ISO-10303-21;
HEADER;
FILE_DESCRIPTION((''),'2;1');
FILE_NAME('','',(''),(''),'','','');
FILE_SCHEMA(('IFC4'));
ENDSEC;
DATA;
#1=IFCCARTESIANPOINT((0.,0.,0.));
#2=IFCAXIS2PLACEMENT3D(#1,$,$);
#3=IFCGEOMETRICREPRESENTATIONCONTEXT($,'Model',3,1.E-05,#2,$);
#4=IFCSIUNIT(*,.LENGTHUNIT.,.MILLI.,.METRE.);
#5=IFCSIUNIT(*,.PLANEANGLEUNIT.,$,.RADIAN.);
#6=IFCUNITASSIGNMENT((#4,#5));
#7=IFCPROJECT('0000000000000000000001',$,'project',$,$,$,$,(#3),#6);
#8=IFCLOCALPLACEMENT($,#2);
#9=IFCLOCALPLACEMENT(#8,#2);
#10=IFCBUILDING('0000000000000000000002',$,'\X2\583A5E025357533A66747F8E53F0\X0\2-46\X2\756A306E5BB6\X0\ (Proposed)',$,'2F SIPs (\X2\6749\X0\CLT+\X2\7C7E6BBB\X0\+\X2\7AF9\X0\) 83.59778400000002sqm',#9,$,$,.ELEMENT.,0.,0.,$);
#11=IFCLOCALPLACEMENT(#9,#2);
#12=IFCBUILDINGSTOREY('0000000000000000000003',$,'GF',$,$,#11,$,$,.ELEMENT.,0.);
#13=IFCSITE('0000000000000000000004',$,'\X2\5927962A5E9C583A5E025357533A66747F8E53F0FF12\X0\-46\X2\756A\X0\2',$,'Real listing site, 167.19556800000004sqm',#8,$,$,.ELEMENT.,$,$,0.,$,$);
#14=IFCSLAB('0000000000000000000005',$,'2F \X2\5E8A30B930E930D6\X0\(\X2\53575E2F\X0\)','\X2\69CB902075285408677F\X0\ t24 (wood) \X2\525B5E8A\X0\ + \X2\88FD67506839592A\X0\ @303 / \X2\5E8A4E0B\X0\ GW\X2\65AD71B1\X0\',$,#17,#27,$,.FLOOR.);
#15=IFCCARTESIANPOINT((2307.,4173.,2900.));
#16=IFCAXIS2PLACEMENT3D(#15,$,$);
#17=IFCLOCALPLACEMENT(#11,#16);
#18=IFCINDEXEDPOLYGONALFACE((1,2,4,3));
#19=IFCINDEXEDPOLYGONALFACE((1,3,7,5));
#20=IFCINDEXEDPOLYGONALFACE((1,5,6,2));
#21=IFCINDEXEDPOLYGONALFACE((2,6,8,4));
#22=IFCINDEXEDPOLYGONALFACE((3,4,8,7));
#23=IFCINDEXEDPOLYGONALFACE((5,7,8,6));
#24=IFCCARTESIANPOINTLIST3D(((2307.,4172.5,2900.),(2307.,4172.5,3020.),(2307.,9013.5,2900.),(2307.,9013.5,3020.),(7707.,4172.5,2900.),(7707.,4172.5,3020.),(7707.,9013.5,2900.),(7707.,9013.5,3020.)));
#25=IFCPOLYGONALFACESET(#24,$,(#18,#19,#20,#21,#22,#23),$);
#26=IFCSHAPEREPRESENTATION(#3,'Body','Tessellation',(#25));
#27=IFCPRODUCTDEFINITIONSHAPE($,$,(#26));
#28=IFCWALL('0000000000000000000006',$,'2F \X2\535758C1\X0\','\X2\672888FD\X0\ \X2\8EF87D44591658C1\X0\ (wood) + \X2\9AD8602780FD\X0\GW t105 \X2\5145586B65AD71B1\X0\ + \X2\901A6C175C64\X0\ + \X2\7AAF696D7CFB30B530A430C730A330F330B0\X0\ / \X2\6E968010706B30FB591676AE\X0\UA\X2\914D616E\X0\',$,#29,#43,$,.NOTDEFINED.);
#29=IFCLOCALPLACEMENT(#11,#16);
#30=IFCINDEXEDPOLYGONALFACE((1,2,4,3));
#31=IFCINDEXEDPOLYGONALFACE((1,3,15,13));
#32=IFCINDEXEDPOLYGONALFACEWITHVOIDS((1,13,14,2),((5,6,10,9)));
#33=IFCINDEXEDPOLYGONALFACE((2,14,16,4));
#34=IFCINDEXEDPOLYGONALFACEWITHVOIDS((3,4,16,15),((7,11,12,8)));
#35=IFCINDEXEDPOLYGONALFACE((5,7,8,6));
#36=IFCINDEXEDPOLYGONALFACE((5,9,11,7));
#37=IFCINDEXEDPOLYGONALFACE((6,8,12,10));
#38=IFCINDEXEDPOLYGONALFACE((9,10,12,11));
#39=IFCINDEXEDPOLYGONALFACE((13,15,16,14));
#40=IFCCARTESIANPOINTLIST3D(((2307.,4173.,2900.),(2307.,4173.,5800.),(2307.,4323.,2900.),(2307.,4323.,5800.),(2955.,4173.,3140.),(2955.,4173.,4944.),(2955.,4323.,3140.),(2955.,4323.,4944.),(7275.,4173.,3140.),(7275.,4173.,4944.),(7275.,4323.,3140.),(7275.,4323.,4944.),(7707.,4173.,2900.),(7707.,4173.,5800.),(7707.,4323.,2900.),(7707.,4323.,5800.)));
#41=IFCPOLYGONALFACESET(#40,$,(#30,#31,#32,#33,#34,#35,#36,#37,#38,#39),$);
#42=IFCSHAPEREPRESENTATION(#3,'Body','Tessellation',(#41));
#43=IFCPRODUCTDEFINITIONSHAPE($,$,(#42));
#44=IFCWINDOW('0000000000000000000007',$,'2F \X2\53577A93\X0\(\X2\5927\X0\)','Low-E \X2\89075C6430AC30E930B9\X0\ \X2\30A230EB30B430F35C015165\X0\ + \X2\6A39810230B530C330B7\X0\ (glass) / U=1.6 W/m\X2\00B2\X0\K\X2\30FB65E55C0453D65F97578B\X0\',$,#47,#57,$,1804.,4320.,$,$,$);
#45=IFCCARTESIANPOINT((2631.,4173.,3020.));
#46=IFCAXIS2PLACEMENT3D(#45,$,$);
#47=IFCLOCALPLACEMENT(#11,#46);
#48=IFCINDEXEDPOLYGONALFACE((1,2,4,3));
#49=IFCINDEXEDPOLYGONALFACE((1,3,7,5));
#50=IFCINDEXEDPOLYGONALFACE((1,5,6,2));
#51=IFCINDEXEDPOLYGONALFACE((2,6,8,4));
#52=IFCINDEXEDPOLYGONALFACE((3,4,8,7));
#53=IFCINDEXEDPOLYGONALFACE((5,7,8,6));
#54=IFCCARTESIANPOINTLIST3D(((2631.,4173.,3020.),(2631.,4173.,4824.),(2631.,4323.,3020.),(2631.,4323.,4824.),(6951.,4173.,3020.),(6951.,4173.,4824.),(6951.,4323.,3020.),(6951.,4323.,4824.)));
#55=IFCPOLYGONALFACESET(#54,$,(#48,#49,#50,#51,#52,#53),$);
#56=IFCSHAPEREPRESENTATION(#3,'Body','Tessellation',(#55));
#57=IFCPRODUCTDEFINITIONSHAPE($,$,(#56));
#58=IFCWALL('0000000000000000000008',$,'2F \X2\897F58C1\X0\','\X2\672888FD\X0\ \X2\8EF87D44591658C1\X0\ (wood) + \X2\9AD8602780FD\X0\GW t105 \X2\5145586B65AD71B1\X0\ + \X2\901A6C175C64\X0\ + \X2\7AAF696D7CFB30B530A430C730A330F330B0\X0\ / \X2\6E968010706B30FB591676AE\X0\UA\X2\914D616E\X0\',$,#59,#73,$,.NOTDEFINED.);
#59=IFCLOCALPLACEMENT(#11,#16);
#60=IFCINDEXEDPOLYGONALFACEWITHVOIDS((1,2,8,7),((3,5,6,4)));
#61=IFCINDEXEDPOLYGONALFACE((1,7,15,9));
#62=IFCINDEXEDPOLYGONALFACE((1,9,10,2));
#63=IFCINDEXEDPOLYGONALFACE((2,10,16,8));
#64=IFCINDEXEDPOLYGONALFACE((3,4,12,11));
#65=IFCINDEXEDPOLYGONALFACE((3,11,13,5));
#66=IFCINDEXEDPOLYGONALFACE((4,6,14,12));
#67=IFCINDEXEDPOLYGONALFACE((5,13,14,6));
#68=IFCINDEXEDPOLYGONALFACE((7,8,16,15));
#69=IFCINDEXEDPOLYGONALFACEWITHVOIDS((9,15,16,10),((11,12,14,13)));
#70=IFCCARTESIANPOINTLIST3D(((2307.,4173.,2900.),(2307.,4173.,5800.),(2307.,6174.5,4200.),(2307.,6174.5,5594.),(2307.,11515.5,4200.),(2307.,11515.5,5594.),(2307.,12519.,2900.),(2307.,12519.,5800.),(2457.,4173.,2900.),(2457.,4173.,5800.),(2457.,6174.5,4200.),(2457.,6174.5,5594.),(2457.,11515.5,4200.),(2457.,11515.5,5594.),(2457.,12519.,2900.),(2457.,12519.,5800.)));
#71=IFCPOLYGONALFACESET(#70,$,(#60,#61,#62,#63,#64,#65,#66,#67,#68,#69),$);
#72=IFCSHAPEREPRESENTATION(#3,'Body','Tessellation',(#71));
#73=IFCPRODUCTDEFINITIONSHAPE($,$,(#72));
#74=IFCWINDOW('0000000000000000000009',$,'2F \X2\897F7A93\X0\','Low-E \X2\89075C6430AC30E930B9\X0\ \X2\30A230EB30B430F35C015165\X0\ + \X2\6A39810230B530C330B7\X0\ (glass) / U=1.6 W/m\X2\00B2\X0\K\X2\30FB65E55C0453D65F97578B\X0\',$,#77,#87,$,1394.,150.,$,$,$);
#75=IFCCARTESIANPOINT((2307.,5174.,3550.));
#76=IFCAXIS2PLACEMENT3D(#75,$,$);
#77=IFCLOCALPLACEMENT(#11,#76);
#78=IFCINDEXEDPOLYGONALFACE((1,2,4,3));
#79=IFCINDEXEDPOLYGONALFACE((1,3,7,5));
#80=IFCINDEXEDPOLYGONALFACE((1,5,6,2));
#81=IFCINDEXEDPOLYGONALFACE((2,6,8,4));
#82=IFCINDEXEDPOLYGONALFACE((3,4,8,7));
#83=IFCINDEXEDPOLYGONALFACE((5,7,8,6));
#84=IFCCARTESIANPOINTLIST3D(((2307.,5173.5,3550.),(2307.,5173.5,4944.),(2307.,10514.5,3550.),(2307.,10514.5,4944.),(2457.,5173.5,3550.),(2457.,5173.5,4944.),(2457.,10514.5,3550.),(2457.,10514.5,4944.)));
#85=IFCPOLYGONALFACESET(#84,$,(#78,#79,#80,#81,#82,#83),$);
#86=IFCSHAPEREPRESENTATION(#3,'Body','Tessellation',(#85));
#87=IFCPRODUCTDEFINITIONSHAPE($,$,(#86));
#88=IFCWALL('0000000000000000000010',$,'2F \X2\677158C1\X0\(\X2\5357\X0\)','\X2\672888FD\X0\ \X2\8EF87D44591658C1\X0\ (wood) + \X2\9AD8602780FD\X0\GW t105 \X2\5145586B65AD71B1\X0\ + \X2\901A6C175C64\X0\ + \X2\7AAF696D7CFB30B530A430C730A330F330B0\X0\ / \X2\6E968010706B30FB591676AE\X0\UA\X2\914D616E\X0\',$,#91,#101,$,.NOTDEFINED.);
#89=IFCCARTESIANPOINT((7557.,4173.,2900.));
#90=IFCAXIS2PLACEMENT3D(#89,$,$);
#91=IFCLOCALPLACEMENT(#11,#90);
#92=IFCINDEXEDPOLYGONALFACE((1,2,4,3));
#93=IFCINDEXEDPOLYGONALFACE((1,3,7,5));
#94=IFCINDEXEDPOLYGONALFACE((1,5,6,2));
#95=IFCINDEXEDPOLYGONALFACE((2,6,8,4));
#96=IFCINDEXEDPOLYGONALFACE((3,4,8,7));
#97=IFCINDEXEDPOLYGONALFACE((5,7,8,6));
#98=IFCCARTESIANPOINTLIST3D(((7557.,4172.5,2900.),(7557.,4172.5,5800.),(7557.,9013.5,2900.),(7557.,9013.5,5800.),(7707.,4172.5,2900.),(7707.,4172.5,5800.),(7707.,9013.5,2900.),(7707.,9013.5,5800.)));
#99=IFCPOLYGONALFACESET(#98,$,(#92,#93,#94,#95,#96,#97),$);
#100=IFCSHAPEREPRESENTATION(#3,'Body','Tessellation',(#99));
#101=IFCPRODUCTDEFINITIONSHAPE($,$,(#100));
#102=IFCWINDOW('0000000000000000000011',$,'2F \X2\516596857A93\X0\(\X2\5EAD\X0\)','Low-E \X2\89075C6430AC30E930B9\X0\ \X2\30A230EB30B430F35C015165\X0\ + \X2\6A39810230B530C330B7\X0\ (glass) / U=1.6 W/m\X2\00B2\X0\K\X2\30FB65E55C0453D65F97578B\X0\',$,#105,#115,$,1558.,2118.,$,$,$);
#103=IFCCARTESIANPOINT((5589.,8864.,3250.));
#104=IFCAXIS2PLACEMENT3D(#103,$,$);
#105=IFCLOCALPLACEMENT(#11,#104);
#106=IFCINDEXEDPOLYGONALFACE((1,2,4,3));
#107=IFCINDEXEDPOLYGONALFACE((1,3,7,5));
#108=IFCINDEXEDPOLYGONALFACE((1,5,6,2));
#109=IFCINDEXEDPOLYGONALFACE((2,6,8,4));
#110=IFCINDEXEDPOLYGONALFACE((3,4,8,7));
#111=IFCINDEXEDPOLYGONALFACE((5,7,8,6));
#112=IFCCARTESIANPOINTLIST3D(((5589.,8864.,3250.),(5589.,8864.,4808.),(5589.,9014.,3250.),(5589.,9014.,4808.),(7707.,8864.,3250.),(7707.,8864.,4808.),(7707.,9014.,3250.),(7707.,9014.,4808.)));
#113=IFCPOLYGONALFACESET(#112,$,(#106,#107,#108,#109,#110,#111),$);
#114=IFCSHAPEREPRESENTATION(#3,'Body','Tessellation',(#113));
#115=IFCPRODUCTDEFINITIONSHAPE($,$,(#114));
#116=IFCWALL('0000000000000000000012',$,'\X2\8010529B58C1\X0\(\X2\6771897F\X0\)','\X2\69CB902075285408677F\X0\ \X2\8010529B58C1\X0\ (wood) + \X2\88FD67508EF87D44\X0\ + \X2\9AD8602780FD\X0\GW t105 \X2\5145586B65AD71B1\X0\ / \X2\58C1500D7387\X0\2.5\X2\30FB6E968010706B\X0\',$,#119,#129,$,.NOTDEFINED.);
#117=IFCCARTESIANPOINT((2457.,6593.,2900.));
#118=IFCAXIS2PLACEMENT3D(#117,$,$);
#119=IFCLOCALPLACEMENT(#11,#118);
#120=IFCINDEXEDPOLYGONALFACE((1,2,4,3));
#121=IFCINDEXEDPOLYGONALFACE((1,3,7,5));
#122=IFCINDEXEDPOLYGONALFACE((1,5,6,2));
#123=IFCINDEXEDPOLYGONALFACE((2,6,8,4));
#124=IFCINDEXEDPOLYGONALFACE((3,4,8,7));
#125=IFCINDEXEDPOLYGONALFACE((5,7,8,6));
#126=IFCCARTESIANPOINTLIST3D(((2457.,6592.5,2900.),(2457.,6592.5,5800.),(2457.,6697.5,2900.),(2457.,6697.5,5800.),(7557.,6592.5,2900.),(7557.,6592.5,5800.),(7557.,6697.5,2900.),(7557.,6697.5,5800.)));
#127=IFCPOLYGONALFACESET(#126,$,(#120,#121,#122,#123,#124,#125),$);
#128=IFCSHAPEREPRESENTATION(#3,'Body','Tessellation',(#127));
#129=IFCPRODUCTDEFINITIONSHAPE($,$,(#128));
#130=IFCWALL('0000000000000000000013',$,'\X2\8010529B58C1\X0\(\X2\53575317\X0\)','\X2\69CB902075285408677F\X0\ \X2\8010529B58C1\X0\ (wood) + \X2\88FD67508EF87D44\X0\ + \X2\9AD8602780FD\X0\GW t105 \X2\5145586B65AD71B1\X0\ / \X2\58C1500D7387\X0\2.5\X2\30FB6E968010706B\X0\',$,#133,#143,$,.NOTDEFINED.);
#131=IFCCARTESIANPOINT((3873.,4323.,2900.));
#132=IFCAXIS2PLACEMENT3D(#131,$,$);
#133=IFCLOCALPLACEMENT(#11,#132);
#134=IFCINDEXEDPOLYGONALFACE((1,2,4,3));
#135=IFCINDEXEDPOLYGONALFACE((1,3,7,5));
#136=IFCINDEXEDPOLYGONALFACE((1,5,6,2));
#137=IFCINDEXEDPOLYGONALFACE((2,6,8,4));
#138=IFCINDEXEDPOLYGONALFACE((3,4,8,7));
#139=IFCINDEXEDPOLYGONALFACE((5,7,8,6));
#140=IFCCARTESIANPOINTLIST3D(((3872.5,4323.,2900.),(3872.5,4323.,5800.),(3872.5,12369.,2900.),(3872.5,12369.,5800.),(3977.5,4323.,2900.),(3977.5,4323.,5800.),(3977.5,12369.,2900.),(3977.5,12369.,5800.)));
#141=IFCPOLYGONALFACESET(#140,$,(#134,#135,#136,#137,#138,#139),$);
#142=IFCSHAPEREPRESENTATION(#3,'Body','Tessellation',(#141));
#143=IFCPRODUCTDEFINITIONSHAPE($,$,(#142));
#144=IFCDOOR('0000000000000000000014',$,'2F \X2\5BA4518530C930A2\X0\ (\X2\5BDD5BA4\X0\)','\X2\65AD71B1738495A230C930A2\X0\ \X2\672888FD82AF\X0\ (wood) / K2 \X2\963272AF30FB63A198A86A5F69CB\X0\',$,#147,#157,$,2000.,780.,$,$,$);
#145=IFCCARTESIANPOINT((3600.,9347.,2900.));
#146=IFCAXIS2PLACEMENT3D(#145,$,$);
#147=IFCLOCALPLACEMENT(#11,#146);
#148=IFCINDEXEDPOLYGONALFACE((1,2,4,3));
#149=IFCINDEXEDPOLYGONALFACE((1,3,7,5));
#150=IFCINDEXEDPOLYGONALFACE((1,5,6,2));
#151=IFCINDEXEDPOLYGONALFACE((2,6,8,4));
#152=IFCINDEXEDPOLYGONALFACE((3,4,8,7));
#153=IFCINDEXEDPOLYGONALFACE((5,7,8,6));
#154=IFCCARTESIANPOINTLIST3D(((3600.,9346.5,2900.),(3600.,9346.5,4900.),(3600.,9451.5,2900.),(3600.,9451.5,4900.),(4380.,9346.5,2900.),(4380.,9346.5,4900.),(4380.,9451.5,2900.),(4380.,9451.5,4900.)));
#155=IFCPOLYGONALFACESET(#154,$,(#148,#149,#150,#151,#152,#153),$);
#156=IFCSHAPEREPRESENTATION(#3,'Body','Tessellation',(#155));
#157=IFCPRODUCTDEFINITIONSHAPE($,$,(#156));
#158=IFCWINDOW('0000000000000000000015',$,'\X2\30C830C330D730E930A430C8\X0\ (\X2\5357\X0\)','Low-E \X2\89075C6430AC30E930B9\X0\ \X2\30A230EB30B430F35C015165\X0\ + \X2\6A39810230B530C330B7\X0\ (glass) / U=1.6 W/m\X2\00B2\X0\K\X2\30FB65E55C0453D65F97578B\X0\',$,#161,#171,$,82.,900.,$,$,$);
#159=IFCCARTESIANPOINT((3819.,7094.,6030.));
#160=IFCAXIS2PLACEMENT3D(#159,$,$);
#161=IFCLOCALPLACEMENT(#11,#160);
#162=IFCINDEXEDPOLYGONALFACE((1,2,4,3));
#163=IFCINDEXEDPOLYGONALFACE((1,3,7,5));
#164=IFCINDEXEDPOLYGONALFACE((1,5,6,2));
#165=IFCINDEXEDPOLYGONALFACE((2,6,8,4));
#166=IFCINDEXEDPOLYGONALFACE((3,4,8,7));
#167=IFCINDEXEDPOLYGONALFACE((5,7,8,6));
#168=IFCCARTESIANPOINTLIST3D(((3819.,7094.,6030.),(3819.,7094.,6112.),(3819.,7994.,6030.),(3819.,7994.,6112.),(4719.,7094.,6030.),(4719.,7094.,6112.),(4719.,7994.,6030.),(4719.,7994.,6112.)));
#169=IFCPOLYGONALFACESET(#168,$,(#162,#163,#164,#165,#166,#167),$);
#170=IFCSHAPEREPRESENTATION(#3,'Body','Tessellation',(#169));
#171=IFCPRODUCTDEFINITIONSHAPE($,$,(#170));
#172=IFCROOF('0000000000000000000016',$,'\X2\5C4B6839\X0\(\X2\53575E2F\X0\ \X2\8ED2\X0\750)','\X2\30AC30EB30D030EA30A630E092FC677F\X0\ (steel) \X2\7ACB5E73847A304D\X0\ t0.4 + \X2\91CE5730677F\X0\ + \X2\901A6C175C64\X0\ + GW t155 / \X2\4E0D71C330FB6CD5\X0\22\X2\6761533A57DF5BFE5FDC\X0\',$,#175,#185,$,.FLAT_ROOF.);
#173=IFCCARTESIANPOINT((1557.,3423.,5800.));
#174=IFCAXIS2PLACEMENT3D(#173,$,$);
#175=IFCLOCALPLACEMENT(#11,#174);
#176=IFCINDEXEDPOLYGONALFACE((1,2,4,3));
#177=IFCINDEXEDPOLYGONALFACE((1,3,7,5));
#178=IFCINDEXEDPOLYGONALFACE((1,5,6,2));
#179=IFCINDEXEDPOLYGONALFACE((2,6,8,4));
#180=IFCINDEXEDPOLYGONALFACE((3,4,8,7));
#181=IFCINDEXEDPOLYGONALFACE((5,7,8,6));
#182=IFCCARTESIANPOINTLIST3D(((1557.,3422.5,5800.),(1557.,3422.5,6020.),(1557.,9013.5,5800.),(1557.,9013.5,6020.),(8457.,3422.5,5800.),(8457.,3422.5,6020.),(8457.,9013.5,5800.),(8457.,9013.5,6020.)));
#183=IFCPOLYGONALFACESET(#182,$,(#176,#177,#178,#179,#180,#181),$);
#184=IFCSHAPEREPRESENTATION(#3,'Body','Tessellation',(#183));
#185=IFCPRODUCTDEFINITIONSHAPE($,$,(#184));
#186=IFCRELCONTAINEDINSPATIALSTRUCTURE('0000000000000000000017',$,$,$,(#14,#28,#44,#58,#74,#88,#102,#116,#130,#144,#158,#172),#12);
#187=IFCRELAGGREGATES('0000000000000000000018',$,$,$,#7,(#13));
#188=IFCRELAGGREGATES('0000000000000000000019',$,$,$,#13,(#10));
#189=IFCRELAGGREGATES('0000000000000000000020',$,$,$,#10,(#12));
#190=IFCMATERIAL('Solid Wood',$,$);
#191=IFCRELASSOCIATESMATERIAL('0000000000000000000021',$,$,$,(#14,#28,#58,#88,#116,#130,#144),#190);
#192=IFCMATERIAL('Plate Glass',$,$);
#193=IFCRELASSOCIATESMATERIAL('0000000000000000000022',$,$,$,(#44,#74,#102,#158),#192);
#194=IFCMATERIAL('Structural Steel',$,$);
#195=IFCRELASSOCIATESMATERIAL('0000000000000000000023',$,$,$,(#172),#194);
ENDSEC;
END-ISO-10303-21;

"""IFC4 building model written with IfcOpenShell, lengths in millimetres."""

from ifc_helpers import new_model, si_unit, frame, frame_2d, origin, place, context, project, spatial, rectangle, extrude, material, element, fill, save


model = new_model("IFC4")

# Units and contexts
model_context = context("Model", 3, precision=1e-05, world=origin())
ifc_project = project(units=[si_unit("LENGTHUNIT", "METRE", prefix="MILLI"), si_unit("PLANEANGLEUNIT", "RADIAN")], contexts=[model_context])

# Site, building, storey
site_placement = place(None, origin())
site = spatial("IfcSite", under=ifc_project, at=site_placement, Name="大阪府堺市南区晴美台２-46番2", ObjectType="Real listing site, 167.19556800000004sqm", CompositionType="ELEMENT", RefElevation=0.0)
building_placement = place(site_placement, origin())
building = spatial("IfcBuilding", under=site, at=building_placement, Name="堺市南区晴美台2-46番の家 (Proposed)", ObjectType="2F SIPs (杉CLT+籾殻+竹) 83.59778400000002sqm", CompositionType="ELEMENT", ElevationOfRefHeight=0.0, ElevationOfTerrain=0.0)
storey_placement = place(building_placement, origin())
storey = spatial("IfcBuildingStorey", under=building, at=storey_placement, Name="GF", CompositionType="ELEMENT", Elevation=0.0)

# Slab
ifc_material_1 = material(Name="Solid Wood")
slab_placement = place(storey_placement, frame((2307.0, 4173.0, 2900.0)))
element("IfcSlab", 1, at=slab_placement, inside=storey, material=ifc_material_1, Name="2F 床スラブ(南帯)", Description="構造用合板 t24 (wood) 剛床 + 製材根太 @303 / 床下 GW断熱", PredefinedType="FLOOR", context=model_context, shape_type="SweptSolid", body=[
    extrude(rectangle(XDim=5400.0, YDim=4841.0, at=frame_2d((2700.0, 2420.0))), frame((2307.0, 4173.0, 2900.0)), (0.0, 0.0, 1.0), 120.0),
])

# Walls, openings, windows
wall_1_placement = place(storey_placement, frame((2307.0, 4173.0, 2900.0)))
wall_1 = element("IfcWall", 2, at=wall_1_placement, inside=storey, material=ifc_material_1, Name="2F 南壁", Description="木製 軸組外壁 (wood) + 高性能GW t105 充填断熱 + 通気層 + 窯業系サイディング / 準耐火・外皮UA配慮", PredefinedType="NOTDEFINED", context=model_context, shape_type="SweptSolid", body=[
    extrude(rectangle(XDim=5400.0, YDim=150.0, at=frame_2d((2700.0, 75.0))), frame((2307.0, 4173.0, 2900.0)), (0.0, 0.0, 1.0), 2900.0),
])
opening_1_placement = place(storey_placement, frame((2631.0, 4173.0, 3020.0)))
opening_1 = element("IfcOpeningElement", 3, at=opening_1_placement, cuts=wall_1, PredefinedType="NOTDEFINED", context=model_context, shape_type="SweptSolid", body=[
    extrude(rectangle(XDim=4320.0, YDim=150.0, at=frame_2d((2160.0, 75.0))), frame((2631.0, 4173.0, 3020.0)), (0.0, 0.0, 1.0), 1804.0),
])
ifc_material_2 = material(Name="Plate Glass")
window_1_placement = place(storey_placement, frame((2631.0, 4173.0, 3020.0)))
window_1 = element("IfcWindow", 4, at=window_1_placement, inside=storey, material=ifc_material_2, Name="2F 南窓(大)", Description="Low-E 複層ガラス アルゴン封入 + 樹脂サッシ (glass) / U=1.6 W/m²K・日射取得型", OverallHeight=1804.0, OverallWidth=4320.0, context=model_context, shape_type="SweptSolid", body=[
    extrude(rectangle(XDim=4320.0, YDim=150.0, at=frame_2d((2160.0, 75.0))), frame((2631.0, 4173.0, 3020.0)), (0.0, 0.0, 1.0), 1804.0),
])
fill(opening_1, window_1)
wall_2_placement = place(storey_placement, frame((2307.0, 4173.0, 2900.0)))
wall_2 = element("IfcWall", 5, at=wall_2_placement, inside=storey, material=ifc_material_1, Name="2F 西壁", Description="木製 軸組外壁 (wood) + 高性能GW t105 充填断熱 + 通気層 + 窯業系サイディング / 準耐火・外皮UA配慮", PredefinedType="NOTDEFINED", context=model_context, shape_type="SweptSolid", body=[
    extrude(rectangle(XDim=150.0, YDim=8346.0, at=frame_2d((75.0, 4173.0))), frame((2307.0, 4173.0, 2900.0)), (0.0, 0.0, 1.0), 2900.0),
])
opening_2_placement = place(storey_placement, frame((2307.0, 5174.0, 3550.0)))
opening_2 = element("IfcOpeningElement", 6, at=opening_2_placement, cuts=wall_2, PredefinedType="NOTDEFINED", context=model_context, shape_type="SweptSolid", body=[
    extrude(rectangle(XDim=150.0, YDim=5341.0, at=frame_2d((75.0, 2670.0))), frame((2307.0, 5174.0, 3550.0)), (0.0, 0.0, 1.0), 1394.0),
])
window_2_placement = place(storey_placement, frame((2307.0, 5174.0, 3550.0)))
window_2 = element("IfcWindow", 7, at=window_2_placement, inside=storey, material=ifc_material_2, Name="2F 西窓", Description="Low-E 複層ガラス アルゴン封入 + 樹脂サッシ (glass) / U=1.6 W/m²K・日射取得型", OverallHeight=1394.0, OverallWidth=150.0, context=model_context, shape_type="SweptSolid", body=[
    extrude(rectangle(XDim=150.0, YDim=5341.0, at=frame_2d((75.0, 2670.0))), frame((2307.0, 5174.0, 3550.0)), (0.0, 0.0, 1.0), 1394.0),
])
fill(opening_2, window_2)
wall_3_placement = place(storey_placement, frame((7557.0, 4173.0, 2900.0)))
wall_3 = element("IfcWall", 8, at=wall_3_placement, inside=storey, material=ifc_material_1, Name="2F 東壁(南)", Description="木製 軸組外壁 (wood) + 高性能GW t105 充填断熱 + 通気層 + 窯業系サイディング / 準耐火・外皮UA配慮", PredefinedType="NOTDEFINED", context=model_context, shape_type="SweptSolid", body=[
    extrude(rectangle(XDim=150.0, YDim=4841.0, at=frame_2d((75.0, 2420.0))), frame((7557.0, 4173.0, 2900.0)), (0.0, 0.0, 1.0), 2900.0),
])
opening_3_placement = place(storey_placement, frame((5589.0, 8864.0, 3250.0)))
opening_3 = element("IfcOpeningElement", 9, at=opening_3_placement, cuts=wall_3, PredefinedType="NOTDEFINED", context=model_context, shape_type="SweptSolid", body=[
    extrude(rectangle(XDim=2118.0, YDim=150.0, at=frame_2d((1059.0, 75.0))), frame((5589.0, 8864.0, 3250.0)), (0.0, 0.0, 1.0), 1558.0),
])
window_3_placement = place(storey_placement, frame((5589.0, 8864.0, 3250.0)))
window_3 = element("IfcWindow", 10, at=window_3_placement, inside=storey, material=ifc_material_2, Name="2F 入隅窓(庭)", Description="Low-E 複層ガラス アルゴン封入 + 樹脂サッシ (glass) / U=1.6 W/m²K・日射取得型", OverallHeight=1558.0, OverallWidth=2118.0, context=model_context, shape_type="SweptSolid", body=[
    extrude(rectangle(XDim=2118.0, YDim=150.0, at=frame_2d((1059.0, 75.0))), frame((5589.0, 8864.0, 3250.0)), (0.0, 0.0, 1.0), 1558.0),
])
fill(opening_3, window_3)

# Wall
wall_4_placement = place(storey_placement, frame((2457.0, 6593.0, 2900.0)))
element("IfcWall", 11, at=wall_4_placement, inside=storey, material=ifc_material_1, Name="耐力壁(東西)", Description="構造用合板 耐力壁 (wood) + 製材軸組 + 高性能GW t105 充填断熱 / 壁倍率2.5・準耐火", PredefinedType="NOTDEFINED", context=model_context, shape_type="SweptSolid", body=[
    extrude(rectangle(XDim=5100.0, YDim=105.0, at=frame_2d((2550.0, 52.0))), frame((2457.0, 6593.0, 2900.0)), (0.0, 0.0, 1.0), 2900.0),
])

# Wall, opening, door
wall_5_placement = place(storey_placement, frame((3873.0, 4323.0, 2900.0)))
wall_5 = element("IfcWall", 12, at=wall_5_placement, inside=storey, material=ifc_material_1, Name="耐力壁(南北)", Description="構造用合板 耐力壁 (wood) + 製材軸組 + 高性能GW t105 充填断熱 / 壁倍率2.5・準耐火", PredefinedType="NOTDEFINED", context=model_context, shape_type="SweptSolid", body=[
    extrude(rectangle(XDim=105.0, YDim=8046.0, at=frame_2d((52.0, 4023.0))), frame((3873.0, 4323.0, 2900.0)), (0.0, 0.0, 1.0), 2900.0),
])
opening_4_placement = place(storey_placement, frame((3600.0, 9347.0, 2900.0)))
opening_4 = element("IfcOpeningElement", 13, at=opening_4_placement, cuts=wall_5, PredefinedType="NOTDEFINED", context=model_context, shape_type="SweptSolid", body=[
    extrude(rectangle(XDim=780.0, YDim=105.0, at=frame_2d((390.0, 52.0))), frame((3600.0, 9347.0, 2900.0)), (0.0, 0.0, 1.0), 2000.0),
])
door_placement = place(storey_placement, frame((3600.0, 9347.0, 2900.0)))
door = element("IfcDoor", 14, at=door_placement, inside=storey, material=ifc_material_1, Name="2F 室内ドア (寝室)", Description="断熱玄関ドア 木製芯 (wood) / K2 防犯・採風機構", OverallHeight=2000.0, OverallWidth=780.0, context=model_context, shape_type="SweptSolid", body=[
    extrude(rectangle(XDim=780.0, YDim=105.0, at=frame_2d((390.0, 52.0))), frame((3600.0, 9347.0, 2900.0)), (0.0, 0.0, 1.0), 2000.0),
])
fill(opening_4, door)

# Window
window_4_placement = place(storey_placement, frame((3819.0, 7094.0, 6030.0)))
element("IfcWindow", 15, at=window_4_placement, inside=storey, material=ifc_material_2, Name="トップライト (南)", Description="Low-E 複層ガラス アルゴン封入 + 樹脂サッシ (glass) / U=1.6 W/m²K・日射取得型", OverallHeight=82.0, OverallWidth=900.0, context=model_context, shape_type="SweptSolid", body=[
    extrude(rectangle(XDim=900.0, YDim=900.0, at=frame_2d((450.0, 450.0))), frame((3819.0, 7094.0, 6030.0)), (0.0, 0.0, 1.0), 82.0),
])

# Roof
ifc_material_3 = material(Name="Structural Steel")
for number, where, name in (
    (16, (1557.0, 3423.0, 5800.0), "屋根(南帯 軒750)"),
):
    element("IfcRoof", number, at=place(storey_placement, frame(where)), inside=storey, material=ifc_material_3, Name=name, Description="ガルバリウム鋼板 (steel) 立平葺き t0.4 + 野地板 + 通気層 + GW t155 / 不燃・法22条区域対応", PredefinedType="FLAT_ROOF", context=model_context, shape_type="SweptSolid", body=[
        extrude(rectangle(XDim=6900.0, YDim=5591.0, at=frame_2d((3450.0, 2795.0))), frame((1557.0, 3423.0, 5800.0)), (0.0, 0.0, 1.0), 220.0),
    ])

save(model, "model.ifc")
